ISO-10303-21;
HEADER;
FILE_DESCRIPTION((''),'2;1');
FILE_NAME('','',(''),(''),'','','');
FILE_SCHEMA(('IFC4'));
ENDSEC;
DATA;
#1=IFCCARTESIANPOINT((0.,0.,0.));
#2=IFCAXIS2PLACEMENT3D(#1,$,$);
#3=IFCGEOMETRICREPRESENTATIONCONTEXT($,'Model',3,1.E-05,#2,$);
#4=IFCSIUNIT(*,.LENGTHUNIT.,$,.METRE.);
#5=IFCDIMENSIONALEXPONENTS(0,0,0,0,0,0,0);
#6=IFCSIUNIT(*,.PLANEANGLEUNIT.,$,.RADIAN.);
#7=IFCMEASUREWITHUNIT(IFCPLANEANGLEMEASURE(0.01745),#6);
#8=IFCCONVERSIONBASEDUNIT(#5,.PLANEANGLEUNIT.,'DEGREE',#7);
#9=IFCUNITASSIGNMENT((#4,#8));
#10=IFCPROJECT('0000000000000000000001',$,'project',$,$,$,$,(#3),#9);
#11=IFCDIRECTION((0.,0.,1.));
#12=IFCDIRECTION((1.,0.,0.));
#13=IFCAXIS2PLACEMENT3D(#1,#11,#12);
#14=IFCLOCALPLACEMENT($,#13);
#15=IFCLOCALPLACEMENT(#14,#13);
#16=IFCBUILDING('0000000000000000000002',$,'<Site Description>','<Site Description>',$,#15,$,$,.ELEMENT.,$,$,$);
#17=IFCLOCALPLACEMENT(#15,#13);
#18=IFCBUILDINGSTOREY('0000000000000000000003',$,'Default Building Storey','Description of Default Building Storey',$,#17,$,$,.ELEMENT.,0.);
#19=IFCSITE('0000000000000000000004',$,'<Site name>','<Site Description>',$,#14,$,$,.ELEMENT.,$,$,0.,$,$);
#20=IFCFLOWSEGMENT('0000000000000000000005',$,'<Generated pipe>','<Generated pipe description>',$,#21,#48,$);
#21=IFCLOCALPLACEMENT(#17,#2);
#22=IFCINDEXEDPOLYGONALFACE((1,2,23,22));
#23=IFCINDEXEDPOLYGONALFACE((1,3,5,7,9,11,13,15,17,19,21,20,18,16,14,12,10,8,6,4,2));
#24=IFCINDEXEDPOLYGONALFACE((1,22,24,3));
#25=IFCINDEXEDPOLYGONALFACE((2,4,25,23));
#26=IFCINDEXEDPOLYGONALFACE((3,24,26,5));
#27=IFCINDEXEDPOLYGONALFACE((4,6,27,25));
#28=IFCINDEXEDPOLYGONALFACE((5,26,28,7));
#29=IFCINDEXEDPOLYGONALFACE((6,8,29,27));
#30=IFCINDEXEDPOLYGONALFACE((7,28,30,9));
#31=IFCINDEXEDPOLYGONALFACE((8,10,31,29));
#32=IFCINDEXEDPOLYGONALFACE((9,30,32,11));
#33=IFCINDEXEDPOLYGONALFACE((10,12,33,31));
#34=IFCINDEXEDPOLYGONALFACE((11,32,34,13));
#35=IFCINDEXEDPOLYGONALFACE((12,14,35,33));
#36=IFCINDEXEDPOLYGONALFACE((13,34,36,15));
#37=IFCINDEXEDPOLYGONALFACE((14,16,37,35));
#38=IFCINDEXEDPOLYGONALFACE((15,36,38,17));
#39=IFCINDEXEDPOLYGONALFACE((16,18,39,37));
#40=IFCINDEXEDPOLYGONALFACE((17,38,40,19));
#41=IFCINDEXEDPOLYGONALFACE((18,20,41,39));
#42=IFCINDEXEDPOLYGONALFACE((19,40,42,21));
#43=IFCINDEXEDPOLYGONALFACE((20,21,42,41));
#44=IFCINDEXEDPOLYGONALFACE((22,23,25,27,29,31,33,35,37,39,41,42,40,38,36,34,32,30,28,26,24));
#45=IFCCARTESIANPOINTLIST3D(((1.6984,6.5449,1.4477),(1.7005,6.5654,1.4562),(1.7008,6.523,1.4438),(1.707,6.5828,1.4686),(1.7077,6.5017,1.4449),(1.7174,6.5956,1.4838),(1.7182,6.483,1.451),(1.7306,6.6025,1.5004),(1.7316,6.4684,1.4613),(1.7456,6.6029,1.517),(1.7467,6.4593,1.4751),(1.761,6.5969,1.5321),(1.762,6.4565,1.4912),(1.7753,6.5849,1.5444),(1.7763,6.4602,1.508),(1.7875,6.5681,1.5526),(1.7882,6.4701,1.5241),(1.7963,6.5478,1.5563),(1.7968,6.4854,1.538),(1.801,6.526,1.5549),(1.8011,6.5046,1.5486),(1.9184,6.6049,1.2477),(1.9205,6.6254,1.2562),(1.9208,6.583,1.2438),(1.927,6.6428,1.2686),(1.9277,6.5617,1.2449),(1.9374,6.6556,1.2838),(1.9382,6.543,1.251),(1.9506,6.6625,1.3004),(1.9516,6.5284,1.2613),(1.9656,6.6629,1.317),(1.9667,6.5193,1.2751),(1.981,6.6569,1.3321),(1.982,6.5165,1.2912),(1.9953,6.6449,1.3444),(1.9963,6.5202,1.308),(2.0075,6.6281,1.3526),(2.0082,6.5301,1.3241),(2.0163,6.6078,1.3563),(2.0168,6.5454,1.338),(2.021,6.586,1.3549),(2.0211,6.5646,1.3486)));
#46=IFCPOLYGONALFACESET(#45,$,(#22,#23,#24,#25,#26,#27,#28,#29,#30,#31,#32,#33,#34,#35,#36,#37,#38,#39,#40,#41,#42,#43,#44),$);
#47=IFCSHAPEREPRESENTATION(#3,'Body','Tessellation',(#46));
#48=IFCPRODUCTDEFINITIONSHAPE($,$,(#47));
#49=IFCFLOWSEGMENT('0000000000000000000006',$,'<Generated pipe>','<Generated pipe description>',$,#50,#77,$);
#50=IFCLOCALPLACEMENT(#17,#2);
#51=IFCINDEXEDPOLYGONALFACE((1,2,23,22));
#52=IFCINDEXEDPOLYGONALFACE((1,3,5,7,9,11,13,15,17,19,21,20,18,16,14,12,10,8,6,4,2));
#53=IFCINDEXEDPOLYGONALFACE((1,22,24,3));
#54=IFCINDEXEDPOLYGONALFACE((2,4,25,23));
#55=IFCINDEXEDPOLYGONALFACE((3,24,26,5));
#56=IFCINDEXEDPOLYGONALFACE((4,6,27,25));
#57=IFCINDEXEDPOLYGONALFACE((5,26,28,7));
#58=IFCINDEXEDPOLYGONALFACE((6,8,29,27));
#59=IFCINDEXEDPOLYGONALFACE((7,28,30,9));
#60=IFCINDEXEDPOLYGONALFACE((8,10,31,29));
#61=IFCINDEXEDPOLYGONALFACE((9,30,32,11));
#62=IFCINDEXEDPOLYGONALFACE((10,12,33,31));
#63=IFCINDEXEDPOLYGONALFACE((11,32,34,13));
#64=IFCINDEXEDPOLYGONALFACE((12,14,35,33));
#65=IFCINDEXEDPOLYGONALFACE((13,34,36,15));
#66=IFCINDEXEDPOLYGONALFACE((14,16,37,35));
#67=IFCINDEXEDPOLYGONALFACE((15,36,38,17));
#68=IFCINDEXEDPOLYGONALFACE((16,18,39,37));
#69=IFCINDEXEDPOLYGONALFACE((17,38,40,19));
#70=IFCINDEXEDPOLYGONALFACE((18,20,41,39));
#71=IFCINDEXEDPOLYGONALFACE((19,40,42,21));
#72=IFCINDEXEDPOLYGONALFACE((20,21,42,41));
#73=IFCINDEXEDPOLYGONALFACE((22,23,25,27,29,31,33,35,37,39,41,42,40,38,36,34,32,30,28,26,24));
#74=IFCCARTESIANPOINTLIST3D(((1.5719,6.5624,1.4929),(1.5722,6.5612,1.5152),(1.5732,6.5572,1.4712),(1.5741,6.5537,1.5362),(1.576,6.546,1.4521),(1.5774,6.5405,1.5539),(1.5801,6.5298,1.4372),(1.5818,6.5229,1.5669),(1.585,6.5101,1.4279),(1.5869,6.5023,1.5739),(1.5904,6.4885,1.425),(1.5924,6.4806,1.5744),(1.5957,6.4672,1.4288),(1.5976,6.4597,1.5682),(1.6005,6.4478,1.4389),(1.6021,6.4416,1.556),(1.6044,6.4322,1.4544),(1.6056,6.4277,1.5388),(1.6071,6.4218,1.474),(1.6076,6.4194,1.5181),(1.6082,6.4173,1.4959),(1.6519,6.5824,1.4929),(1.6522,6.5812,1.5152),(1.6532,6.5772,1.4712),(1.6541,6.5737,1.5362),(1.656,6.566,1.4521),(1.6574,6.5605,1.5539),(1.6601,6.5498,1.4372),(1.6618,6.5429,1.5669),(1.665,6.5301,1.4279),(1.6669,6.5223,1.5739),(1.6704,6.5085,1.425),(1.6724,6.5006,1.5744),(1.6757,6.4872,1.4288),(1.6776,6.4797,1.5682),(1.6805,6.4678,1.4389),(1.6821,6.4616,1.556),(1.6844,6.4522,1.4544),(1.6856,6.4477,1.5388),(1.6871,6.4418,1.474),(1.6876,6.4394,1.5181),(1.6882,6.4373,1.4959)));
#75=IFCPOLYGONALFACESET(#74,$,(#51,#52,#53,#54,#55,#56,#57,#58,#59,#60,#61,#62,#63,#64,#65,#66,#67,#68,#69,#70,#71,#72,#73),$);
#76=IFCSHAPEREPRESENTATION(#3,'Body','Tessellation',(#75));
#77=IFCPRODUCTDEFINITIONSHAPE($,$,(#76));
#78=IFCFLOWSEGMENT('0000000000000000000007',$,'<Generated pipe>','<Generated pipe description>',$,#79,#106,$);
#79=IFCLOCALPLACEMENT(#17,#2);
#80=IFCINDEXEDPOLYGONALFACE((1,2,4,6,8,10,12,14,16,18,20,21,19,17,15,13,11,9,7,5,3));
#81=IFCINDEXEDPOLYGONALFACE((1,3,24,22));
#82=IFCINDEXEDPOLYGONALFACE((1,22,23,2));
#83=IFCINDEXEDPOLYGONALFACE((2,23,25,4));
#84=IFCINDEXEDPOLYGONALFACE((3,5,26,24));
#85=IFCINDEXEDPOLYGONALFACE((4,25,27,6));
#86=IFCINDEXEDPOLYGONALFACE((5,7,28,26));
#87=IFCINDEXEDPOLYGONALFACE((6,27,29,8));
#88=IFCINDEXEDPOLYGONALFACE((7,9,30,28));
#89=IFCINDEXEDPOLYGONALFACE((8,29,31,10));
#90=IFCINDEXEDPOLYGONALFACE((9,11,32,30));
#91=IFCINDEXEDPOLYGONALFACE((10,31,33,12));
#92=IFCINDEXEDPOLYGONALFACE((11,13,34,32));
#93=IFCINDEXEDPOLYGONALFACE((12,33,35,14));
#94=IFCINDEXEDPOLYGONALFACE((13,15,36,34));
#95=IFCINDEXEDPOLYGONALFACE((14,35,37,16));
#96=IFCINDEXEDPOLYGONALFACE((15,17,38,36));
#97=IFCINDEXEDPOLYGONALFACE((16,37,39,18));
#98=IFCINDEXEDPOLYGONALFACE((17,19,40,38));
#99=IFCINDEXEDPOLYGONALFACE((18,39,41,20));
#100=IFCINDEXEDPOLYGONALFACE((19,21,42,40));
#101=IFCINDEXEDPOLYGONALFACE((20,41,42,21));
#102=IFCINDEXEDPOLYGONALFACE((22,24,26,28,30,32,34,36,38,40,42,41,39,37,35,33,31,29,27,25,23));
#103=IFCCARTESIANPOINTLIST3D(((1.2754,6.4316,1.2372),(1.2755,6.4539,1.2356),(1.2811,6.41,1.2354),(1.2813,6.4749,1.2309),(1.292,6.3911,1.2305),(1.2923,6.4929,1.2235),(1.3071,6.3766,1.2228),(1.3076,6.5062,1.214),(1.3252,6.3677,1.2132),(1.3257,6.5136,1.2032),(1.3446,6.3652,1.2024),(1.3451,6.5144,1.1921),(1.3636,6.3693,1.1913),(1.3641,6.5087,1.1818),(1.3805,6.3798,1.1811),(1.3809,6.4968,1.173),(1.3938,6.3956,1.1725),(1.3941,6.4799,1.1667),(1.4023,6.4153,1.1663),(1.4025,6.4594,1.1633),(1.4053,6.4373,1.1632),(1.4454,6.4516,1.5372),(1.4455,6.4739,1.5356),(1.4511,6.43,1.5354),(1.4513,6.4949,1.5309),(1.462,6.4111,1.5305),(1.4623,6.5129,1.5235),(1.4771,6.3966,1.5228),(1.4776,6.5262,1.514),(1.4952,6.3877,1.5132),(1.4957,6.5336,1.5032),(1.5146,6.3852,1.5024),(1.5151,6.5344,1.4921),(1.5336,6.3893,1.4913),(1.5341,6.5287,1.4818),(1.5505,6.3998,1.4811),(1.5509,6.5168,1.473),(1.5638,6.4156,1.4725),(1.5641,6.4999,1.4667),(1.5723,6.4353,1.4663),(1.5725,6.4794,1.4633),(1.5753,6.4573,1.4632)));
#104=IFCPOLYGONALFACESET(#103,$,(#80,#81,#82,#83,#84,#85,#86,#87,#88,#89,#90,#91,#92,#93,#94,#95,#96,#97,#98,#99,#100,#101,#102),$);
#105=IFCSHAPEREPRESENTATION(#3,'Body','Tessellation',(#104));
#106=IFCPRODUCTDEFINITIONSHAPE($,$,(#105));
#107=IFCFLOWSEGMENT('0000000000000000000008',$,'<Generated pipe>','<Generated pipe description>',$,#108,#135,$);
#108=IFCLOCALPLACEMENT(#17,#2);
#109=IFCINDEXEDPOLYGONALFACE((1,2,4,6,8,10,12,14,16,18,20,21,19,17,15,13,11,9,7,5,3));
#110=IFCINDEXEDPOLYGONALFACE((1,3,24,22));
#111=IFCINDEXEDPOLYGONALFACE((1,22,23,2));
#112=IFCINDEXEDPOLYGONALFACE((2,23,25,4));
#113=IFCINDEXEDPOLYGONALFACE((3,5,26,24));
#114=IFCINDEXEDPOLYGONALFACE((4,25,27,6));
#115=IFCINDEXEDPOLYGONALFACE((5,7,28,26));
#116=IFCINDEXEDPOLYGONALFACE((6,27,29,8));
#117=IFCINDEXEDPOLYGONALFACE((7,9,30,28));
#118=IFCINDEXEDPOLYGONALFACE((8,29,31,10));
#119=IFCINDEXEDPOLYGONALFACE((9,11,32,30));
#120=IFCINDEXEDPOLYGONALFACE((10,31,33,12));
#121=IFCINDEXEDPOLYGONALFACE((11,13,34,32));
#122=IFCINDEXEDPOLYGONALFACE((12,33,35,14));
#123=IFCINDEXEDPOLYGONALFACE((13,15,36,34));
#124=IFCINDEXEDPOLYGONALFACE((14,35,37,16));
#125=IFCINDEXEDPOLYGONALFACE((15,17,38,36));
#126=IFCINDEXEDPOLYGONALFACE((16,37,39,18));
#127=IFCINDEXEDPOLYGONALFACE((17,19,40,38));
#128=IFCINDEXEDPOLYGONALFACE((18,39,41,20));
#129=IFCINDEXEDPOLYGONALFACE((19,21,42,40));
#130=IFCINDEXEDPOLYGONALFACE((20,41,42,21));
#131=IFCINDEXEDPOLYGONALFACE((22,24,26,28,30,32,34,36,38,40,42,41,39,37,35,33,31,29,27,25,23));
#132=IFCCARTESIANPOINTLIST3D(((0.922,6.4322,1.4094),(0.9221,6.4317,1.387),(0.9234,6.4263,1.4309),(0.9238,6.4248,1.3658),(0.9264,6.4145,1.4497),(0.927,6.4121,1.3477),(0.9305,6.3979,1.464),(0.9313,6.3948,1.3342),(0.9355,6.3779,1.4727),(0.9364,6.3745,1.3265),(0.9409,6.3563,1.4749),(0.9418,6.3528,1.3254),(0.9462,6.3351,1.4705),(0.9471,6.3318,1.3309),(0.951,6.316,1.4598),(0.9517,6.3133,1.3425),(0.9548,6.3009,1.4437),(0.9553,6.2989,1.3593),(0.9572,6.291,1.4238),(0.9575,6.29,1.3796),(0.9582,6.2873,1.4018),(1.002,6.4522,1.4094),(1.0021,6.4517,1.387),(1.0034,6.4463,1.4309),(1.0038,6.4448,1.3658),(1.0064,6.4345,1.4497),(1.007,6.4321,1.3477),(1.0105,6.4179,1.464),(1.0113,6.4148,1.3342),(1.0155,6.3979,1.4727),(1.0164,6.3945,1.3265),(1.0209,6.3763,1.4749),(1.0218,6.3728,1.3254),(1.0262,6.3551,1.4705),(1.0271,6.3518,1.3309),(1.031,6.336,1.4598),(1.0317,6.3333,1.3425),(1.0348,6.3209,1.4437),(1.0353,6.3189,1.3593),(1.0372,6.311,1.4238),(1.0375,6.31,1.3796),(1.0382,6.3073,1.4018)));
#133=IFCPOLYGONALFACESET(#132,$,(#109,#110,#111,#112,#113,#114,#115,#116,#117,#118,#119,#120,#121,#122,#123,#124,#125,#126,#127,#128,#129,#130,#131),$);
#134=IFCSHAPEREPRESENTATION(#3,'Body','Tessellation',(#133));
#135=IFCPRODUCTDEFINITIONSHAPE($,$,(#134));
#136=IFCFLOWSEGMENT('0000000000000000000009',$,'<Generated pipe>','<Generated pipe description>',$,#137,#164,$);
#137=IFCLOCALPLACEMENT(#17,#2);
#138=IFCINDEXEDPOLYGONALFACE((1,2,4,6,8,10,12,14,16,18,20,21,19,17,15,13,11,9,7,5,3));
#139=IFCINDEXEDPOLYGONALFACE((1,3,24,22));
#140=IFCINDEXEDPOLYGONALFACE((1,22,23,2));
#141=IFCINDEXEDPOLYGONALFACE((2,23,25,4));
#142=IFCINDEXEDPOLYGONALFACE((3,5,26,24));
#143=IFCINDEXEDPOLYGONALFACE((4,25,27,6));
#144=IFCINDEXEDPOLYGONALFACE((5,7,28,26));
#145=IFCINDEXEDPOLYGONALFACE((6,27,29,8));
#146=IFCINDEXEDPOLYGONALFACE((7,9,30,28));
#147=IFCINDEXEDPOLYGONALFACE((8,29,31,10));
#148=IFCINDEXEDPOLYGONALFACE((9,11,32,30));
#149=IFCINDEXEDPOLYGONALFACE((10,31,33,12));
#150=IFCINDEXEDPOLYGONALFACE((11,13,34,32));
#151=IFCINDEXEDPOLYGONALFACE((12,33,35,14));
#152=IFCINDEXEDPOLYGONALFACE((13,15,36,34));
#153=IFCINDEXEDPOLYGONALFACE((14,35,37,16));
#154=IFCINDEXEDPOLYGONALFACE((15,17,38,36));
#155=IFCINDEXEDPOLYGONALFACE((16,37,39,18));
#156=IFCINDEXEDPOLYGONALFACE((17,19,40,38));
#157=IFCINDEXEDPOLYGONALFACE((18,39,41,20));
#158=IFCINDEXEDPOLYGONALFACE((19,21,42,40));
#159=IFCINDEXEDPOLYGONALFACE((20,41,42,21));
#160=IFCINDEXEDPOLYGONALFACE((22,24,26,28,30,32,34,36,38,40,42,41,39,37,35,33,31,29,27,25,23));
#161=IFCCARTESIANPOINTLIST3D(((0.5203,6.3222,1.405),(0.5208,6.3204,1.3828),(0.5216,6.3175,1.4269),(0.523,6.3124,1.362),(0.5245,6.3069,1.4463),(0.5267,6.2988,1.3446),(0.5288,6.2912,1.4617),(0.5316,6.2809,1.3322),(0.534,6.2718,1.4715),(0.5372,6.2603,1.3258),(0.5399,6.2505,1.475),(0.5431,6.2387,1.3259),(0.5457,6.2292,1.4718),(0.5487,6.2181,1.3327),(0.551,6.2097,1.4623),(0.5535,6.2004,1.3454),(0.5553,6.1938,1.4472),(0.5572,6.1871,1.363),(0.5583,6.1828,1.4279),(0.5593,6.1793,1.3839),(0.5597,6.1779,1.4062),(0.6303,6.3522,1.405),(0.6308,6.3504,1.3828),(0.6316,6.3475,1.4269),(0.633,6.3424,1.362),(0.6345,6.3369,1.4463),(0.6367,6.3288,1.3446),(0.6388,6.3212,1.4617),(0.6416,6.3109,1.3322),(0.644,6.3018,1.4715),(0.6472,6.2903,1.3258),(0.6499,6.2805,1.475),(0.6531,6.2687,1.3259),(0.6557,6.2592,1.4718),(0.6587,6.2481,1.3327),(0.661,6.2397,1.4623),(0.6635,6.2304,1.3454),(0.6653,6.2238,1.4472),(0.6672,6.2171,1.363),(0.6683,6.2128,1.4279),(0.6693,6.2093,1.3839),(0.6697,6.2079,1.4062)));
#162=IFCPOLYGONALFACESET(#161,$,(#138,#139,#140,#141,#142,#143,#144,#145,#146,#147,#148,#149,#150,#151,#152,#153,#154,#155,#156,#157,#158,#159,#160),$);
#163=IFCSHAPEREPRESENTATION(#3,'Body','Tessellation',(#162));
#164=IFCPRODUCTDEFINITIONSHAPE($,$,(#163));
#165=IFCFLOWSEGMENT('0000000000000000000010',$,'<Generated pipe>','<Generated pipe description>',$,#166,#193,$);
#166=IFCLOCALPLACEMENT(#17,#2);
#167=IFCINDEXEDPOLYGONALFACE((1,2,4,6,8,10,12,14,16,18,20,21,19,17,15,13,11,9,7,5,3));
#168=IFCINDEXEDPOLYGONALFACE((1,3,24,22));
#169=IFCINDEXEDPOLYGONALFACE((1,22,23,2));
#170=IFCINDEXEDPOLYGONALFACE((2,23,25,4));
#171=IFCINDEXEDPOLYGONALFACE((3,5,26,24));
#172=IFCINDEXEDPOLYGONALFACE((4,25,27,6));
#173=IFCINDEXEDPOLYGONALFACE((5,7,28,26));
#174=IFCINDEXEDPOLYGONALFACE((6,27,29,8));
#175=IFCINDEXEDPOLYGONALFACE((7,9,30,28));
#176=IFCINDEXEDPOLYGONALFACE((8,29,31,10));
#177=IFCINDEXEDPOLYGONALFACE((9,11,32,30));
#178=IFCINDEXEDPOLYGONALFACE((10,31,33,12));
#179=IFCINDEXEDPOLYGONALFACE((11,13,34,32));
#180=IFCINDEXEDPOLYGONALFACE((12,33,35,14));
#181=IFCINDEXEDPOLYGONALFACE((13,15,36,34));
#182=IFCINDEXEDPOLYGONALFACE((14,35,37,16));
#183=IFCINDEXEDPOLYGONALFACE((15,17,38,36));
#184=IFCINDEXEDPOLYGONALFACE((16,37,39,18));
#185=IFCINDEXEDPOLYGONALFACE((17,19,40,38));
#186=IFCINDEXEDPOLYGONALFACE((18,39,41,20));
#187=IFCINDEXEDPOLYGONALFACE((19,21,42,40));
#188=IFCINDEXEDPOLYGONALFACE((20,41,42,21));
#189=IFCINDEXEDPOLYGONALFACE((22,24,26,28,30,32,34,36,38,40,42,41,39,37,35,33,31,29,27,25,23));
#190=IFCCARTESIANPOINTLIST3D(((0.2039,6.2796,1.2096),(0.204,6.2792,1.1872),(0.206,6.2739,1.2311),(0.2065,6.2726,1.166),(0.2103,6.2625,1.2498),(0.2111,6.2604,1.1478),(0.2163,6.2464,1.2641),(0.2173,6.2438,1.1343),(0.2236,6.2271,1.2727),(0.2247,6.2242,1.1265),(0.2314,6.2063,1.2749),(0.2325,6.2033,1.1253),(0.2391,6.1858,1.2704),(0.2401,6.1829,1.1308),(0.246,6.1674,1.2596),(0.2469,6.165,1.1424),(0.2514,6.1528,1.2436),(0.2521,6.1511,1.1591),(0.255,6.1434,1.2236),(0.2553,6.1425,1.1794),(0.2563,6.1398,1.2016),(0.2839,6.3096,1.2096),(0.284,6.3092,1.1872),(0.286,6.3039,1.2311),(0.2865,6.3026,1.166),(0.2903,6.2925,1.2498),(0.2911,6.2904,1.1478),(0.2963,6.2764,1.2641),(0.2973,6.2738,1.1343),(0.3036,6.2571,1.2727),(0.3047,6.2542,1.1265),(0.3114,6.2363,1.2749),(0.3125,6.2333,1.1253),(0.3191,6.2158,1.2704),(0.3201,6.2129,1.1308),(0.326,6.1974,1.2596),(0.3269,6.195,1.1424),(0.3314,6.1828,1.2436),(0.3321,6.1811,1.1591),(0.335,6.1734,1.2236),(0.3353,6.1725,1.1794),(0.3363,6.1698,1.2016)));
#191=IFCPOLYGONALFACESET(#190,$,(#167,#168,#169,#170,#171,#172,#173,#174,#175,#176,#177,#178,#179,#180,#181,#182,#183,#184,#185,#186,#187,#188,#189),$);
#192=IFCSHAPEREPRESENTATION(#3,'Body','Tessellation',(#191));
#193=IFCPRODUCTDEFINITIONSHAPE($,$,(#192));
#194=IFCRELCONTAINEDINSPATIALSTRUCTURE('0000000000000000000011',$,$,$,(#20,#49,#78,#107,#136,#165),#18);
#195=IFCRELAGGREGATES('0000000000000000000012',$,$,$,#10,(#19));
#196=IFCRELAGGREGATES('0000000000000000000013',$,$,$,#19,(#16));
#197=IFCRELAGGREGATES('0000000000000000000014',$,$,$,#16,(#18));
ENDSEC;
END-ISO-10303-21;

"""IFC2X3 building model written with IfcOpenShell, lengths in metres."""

from ifc_helpers import new_model, entity, si_unit, converted_unit, frame, origin, origin_with_axes, origin_2d_with_axis, place, context, project, spatial, circle, extrude, element, save


model = new_model("IFC2X3")

# Units and contexts
model_context = context("Model", 3, precision=1e-05, world=origin())
ifc_project = project(units=[si_unit("LENGTHUNIT", "METRE"), converted_unit("PLANEANGLEUNIT", "DEGREE", entity("IfcPlaneAngleMeasure", 0.01745), si_unit("PLANEANGLEUNIT", "RADIAN"), dimensions=[0, 0, 0, 0, 0, 0, 0])], contexts=[model_context])

# Site, building, storey
site_placement = place(None, origin_with_axes())
site = spatial("IfcSite", under=ifc_project, at=site_placement, Name="<Site name>", Description="<Site Description>", CompositionType="ELEMENT", RefElevation=0.0)
building_placement = place(site_placement, origin_with_axes())
building = spatial("IfcBuilding", under=site, at=building_placement, Name="<Site Description>", Description="<Site Description>", CompositionType="ELEMENT")
storey_placement = place(building_placement, origin_with_axes())
storey = spatial("IfcBuildingStorey", under=building, at=storey_placement, Name="Default Building Storey", Description="Description of Default Building Storey", CompositionType="ELEMENT", Elevation=0.0)

# Flow segments
flow_segment_1_placement = place(storey_placement, frame((1.97, 6.59, 1.3), z_axis=(-0.725319, -0.197814, 0.65938), x_axis=(0.499669, 0.507592, 0.701913)))
element("IfcFlowSegment", 1, at=flow_segment_1_placement, inside=storey, Name="<Generated pipe>", Description="<Generated pipe description>", context=model_context, shape_type="SweptSolid", body=[
    extrude(circle(Radius=0.075, at=origin_2d_with_axis()), origin_with_axes(), (0.0, 0.0, 1.0), 0.3033),
])
flow_segment_2_placement = place(storey_placement, frame((1.67, 6.51, 1.5), z_axis=(-0.970142, -0.242536, 0.0), x_axis=(-0.212426, 0.849704, 0.482574)))
element("IfcFlowSegment", 2, at=flow_segment_2_placement, inside=storey, Name="<Generated pipe>", Description="<Generated pipe description>", context=model_context, shape_type="SweptSolid", body=[
    extrude(circle(Radius=0.075, at=origin_2d_with_axis()), origin_with_axes(), (0.0, 0.0, 1.0), 0.0825),
])
flow_segment_3_placement = place(storey_placement, frame((1.51, 6.46, 1.5), z_axis=(-0.492185, -0.057904, -0.868562), x_axis=(0.870484, -0.03644, -0.490845)))
element("IfcFlowSegment", 3, at=flow_segment_3_placement, inside=storey, Name="<Generated pipe>", Description="<Generated pipe description>", context=model_context, shape_type="SweptSolid", body=[
    extrude(circle(Radius=0.075, at=origin_2d_with_axis()), origin_with_axes(), (0.0, 0.0, 1.0), 0.3454),
])
flow_segment_4_placement = place(storey_placement, frame((1.02, 6.38, 1.4), z_axis=(-0.970142, -0.242536, 0.0), x_axis=(-0.240632, 0.96253, 0.12503)))
element("IfcFlowSegment", 4, at=flow_segment_4_placement, inside=storey, Name="<Generated pipe>", Description="<Generated pipe description>", context=model_context, shape_type="SweptSolid", body=[
    extrude(circle(Radius=0.075, at=origin_2d_with_axis()), origin_with_axes(), (0.0, 0.0, 1.0), 0.0825),
])
flow_segment_5_placement = place(storey_placement, frame((0.65, 6.28, 1.4), z_axis=(-0.964764, -0.263117, 0.0), x_axis=(-0.26252, 0.962575, 0.067326)))
element("IfcFlowSegment", 5, at=flow_segment_5_placement, inside=storey, Name="<Generated pipe>", Description="<Generated pipe description>", context=model_context, shape_type="SweptSolid", body=[
    extrude(circle(Radius=0.075, at=origin_2d_with_axis()), origin_with_axes(), (0.0, 0.0, 1.0), 0.114),
])
flow_segment_6_placement = place(storey_placement, frame((0.31, 6.24, 1.2), z_axis=(-0.936329, -0.351123, 0.0), x_axis=(-0.182036, 0.48543, 0.855114)))
element("IfcFlowSegment", 6, at=flow_segment_6_placement, inside=storey, Name="<Generated pipe>", Description="<Generated pipe description>", context=model_context, shape_type="SweptSolid", body=[
    extrude(circle(Radius=0.075, at=origin_2d_with_axis()), origin_with_axes(), (0.0, 0.0, 1.0), 0.0854),
])

save(model, "model.ifc")
